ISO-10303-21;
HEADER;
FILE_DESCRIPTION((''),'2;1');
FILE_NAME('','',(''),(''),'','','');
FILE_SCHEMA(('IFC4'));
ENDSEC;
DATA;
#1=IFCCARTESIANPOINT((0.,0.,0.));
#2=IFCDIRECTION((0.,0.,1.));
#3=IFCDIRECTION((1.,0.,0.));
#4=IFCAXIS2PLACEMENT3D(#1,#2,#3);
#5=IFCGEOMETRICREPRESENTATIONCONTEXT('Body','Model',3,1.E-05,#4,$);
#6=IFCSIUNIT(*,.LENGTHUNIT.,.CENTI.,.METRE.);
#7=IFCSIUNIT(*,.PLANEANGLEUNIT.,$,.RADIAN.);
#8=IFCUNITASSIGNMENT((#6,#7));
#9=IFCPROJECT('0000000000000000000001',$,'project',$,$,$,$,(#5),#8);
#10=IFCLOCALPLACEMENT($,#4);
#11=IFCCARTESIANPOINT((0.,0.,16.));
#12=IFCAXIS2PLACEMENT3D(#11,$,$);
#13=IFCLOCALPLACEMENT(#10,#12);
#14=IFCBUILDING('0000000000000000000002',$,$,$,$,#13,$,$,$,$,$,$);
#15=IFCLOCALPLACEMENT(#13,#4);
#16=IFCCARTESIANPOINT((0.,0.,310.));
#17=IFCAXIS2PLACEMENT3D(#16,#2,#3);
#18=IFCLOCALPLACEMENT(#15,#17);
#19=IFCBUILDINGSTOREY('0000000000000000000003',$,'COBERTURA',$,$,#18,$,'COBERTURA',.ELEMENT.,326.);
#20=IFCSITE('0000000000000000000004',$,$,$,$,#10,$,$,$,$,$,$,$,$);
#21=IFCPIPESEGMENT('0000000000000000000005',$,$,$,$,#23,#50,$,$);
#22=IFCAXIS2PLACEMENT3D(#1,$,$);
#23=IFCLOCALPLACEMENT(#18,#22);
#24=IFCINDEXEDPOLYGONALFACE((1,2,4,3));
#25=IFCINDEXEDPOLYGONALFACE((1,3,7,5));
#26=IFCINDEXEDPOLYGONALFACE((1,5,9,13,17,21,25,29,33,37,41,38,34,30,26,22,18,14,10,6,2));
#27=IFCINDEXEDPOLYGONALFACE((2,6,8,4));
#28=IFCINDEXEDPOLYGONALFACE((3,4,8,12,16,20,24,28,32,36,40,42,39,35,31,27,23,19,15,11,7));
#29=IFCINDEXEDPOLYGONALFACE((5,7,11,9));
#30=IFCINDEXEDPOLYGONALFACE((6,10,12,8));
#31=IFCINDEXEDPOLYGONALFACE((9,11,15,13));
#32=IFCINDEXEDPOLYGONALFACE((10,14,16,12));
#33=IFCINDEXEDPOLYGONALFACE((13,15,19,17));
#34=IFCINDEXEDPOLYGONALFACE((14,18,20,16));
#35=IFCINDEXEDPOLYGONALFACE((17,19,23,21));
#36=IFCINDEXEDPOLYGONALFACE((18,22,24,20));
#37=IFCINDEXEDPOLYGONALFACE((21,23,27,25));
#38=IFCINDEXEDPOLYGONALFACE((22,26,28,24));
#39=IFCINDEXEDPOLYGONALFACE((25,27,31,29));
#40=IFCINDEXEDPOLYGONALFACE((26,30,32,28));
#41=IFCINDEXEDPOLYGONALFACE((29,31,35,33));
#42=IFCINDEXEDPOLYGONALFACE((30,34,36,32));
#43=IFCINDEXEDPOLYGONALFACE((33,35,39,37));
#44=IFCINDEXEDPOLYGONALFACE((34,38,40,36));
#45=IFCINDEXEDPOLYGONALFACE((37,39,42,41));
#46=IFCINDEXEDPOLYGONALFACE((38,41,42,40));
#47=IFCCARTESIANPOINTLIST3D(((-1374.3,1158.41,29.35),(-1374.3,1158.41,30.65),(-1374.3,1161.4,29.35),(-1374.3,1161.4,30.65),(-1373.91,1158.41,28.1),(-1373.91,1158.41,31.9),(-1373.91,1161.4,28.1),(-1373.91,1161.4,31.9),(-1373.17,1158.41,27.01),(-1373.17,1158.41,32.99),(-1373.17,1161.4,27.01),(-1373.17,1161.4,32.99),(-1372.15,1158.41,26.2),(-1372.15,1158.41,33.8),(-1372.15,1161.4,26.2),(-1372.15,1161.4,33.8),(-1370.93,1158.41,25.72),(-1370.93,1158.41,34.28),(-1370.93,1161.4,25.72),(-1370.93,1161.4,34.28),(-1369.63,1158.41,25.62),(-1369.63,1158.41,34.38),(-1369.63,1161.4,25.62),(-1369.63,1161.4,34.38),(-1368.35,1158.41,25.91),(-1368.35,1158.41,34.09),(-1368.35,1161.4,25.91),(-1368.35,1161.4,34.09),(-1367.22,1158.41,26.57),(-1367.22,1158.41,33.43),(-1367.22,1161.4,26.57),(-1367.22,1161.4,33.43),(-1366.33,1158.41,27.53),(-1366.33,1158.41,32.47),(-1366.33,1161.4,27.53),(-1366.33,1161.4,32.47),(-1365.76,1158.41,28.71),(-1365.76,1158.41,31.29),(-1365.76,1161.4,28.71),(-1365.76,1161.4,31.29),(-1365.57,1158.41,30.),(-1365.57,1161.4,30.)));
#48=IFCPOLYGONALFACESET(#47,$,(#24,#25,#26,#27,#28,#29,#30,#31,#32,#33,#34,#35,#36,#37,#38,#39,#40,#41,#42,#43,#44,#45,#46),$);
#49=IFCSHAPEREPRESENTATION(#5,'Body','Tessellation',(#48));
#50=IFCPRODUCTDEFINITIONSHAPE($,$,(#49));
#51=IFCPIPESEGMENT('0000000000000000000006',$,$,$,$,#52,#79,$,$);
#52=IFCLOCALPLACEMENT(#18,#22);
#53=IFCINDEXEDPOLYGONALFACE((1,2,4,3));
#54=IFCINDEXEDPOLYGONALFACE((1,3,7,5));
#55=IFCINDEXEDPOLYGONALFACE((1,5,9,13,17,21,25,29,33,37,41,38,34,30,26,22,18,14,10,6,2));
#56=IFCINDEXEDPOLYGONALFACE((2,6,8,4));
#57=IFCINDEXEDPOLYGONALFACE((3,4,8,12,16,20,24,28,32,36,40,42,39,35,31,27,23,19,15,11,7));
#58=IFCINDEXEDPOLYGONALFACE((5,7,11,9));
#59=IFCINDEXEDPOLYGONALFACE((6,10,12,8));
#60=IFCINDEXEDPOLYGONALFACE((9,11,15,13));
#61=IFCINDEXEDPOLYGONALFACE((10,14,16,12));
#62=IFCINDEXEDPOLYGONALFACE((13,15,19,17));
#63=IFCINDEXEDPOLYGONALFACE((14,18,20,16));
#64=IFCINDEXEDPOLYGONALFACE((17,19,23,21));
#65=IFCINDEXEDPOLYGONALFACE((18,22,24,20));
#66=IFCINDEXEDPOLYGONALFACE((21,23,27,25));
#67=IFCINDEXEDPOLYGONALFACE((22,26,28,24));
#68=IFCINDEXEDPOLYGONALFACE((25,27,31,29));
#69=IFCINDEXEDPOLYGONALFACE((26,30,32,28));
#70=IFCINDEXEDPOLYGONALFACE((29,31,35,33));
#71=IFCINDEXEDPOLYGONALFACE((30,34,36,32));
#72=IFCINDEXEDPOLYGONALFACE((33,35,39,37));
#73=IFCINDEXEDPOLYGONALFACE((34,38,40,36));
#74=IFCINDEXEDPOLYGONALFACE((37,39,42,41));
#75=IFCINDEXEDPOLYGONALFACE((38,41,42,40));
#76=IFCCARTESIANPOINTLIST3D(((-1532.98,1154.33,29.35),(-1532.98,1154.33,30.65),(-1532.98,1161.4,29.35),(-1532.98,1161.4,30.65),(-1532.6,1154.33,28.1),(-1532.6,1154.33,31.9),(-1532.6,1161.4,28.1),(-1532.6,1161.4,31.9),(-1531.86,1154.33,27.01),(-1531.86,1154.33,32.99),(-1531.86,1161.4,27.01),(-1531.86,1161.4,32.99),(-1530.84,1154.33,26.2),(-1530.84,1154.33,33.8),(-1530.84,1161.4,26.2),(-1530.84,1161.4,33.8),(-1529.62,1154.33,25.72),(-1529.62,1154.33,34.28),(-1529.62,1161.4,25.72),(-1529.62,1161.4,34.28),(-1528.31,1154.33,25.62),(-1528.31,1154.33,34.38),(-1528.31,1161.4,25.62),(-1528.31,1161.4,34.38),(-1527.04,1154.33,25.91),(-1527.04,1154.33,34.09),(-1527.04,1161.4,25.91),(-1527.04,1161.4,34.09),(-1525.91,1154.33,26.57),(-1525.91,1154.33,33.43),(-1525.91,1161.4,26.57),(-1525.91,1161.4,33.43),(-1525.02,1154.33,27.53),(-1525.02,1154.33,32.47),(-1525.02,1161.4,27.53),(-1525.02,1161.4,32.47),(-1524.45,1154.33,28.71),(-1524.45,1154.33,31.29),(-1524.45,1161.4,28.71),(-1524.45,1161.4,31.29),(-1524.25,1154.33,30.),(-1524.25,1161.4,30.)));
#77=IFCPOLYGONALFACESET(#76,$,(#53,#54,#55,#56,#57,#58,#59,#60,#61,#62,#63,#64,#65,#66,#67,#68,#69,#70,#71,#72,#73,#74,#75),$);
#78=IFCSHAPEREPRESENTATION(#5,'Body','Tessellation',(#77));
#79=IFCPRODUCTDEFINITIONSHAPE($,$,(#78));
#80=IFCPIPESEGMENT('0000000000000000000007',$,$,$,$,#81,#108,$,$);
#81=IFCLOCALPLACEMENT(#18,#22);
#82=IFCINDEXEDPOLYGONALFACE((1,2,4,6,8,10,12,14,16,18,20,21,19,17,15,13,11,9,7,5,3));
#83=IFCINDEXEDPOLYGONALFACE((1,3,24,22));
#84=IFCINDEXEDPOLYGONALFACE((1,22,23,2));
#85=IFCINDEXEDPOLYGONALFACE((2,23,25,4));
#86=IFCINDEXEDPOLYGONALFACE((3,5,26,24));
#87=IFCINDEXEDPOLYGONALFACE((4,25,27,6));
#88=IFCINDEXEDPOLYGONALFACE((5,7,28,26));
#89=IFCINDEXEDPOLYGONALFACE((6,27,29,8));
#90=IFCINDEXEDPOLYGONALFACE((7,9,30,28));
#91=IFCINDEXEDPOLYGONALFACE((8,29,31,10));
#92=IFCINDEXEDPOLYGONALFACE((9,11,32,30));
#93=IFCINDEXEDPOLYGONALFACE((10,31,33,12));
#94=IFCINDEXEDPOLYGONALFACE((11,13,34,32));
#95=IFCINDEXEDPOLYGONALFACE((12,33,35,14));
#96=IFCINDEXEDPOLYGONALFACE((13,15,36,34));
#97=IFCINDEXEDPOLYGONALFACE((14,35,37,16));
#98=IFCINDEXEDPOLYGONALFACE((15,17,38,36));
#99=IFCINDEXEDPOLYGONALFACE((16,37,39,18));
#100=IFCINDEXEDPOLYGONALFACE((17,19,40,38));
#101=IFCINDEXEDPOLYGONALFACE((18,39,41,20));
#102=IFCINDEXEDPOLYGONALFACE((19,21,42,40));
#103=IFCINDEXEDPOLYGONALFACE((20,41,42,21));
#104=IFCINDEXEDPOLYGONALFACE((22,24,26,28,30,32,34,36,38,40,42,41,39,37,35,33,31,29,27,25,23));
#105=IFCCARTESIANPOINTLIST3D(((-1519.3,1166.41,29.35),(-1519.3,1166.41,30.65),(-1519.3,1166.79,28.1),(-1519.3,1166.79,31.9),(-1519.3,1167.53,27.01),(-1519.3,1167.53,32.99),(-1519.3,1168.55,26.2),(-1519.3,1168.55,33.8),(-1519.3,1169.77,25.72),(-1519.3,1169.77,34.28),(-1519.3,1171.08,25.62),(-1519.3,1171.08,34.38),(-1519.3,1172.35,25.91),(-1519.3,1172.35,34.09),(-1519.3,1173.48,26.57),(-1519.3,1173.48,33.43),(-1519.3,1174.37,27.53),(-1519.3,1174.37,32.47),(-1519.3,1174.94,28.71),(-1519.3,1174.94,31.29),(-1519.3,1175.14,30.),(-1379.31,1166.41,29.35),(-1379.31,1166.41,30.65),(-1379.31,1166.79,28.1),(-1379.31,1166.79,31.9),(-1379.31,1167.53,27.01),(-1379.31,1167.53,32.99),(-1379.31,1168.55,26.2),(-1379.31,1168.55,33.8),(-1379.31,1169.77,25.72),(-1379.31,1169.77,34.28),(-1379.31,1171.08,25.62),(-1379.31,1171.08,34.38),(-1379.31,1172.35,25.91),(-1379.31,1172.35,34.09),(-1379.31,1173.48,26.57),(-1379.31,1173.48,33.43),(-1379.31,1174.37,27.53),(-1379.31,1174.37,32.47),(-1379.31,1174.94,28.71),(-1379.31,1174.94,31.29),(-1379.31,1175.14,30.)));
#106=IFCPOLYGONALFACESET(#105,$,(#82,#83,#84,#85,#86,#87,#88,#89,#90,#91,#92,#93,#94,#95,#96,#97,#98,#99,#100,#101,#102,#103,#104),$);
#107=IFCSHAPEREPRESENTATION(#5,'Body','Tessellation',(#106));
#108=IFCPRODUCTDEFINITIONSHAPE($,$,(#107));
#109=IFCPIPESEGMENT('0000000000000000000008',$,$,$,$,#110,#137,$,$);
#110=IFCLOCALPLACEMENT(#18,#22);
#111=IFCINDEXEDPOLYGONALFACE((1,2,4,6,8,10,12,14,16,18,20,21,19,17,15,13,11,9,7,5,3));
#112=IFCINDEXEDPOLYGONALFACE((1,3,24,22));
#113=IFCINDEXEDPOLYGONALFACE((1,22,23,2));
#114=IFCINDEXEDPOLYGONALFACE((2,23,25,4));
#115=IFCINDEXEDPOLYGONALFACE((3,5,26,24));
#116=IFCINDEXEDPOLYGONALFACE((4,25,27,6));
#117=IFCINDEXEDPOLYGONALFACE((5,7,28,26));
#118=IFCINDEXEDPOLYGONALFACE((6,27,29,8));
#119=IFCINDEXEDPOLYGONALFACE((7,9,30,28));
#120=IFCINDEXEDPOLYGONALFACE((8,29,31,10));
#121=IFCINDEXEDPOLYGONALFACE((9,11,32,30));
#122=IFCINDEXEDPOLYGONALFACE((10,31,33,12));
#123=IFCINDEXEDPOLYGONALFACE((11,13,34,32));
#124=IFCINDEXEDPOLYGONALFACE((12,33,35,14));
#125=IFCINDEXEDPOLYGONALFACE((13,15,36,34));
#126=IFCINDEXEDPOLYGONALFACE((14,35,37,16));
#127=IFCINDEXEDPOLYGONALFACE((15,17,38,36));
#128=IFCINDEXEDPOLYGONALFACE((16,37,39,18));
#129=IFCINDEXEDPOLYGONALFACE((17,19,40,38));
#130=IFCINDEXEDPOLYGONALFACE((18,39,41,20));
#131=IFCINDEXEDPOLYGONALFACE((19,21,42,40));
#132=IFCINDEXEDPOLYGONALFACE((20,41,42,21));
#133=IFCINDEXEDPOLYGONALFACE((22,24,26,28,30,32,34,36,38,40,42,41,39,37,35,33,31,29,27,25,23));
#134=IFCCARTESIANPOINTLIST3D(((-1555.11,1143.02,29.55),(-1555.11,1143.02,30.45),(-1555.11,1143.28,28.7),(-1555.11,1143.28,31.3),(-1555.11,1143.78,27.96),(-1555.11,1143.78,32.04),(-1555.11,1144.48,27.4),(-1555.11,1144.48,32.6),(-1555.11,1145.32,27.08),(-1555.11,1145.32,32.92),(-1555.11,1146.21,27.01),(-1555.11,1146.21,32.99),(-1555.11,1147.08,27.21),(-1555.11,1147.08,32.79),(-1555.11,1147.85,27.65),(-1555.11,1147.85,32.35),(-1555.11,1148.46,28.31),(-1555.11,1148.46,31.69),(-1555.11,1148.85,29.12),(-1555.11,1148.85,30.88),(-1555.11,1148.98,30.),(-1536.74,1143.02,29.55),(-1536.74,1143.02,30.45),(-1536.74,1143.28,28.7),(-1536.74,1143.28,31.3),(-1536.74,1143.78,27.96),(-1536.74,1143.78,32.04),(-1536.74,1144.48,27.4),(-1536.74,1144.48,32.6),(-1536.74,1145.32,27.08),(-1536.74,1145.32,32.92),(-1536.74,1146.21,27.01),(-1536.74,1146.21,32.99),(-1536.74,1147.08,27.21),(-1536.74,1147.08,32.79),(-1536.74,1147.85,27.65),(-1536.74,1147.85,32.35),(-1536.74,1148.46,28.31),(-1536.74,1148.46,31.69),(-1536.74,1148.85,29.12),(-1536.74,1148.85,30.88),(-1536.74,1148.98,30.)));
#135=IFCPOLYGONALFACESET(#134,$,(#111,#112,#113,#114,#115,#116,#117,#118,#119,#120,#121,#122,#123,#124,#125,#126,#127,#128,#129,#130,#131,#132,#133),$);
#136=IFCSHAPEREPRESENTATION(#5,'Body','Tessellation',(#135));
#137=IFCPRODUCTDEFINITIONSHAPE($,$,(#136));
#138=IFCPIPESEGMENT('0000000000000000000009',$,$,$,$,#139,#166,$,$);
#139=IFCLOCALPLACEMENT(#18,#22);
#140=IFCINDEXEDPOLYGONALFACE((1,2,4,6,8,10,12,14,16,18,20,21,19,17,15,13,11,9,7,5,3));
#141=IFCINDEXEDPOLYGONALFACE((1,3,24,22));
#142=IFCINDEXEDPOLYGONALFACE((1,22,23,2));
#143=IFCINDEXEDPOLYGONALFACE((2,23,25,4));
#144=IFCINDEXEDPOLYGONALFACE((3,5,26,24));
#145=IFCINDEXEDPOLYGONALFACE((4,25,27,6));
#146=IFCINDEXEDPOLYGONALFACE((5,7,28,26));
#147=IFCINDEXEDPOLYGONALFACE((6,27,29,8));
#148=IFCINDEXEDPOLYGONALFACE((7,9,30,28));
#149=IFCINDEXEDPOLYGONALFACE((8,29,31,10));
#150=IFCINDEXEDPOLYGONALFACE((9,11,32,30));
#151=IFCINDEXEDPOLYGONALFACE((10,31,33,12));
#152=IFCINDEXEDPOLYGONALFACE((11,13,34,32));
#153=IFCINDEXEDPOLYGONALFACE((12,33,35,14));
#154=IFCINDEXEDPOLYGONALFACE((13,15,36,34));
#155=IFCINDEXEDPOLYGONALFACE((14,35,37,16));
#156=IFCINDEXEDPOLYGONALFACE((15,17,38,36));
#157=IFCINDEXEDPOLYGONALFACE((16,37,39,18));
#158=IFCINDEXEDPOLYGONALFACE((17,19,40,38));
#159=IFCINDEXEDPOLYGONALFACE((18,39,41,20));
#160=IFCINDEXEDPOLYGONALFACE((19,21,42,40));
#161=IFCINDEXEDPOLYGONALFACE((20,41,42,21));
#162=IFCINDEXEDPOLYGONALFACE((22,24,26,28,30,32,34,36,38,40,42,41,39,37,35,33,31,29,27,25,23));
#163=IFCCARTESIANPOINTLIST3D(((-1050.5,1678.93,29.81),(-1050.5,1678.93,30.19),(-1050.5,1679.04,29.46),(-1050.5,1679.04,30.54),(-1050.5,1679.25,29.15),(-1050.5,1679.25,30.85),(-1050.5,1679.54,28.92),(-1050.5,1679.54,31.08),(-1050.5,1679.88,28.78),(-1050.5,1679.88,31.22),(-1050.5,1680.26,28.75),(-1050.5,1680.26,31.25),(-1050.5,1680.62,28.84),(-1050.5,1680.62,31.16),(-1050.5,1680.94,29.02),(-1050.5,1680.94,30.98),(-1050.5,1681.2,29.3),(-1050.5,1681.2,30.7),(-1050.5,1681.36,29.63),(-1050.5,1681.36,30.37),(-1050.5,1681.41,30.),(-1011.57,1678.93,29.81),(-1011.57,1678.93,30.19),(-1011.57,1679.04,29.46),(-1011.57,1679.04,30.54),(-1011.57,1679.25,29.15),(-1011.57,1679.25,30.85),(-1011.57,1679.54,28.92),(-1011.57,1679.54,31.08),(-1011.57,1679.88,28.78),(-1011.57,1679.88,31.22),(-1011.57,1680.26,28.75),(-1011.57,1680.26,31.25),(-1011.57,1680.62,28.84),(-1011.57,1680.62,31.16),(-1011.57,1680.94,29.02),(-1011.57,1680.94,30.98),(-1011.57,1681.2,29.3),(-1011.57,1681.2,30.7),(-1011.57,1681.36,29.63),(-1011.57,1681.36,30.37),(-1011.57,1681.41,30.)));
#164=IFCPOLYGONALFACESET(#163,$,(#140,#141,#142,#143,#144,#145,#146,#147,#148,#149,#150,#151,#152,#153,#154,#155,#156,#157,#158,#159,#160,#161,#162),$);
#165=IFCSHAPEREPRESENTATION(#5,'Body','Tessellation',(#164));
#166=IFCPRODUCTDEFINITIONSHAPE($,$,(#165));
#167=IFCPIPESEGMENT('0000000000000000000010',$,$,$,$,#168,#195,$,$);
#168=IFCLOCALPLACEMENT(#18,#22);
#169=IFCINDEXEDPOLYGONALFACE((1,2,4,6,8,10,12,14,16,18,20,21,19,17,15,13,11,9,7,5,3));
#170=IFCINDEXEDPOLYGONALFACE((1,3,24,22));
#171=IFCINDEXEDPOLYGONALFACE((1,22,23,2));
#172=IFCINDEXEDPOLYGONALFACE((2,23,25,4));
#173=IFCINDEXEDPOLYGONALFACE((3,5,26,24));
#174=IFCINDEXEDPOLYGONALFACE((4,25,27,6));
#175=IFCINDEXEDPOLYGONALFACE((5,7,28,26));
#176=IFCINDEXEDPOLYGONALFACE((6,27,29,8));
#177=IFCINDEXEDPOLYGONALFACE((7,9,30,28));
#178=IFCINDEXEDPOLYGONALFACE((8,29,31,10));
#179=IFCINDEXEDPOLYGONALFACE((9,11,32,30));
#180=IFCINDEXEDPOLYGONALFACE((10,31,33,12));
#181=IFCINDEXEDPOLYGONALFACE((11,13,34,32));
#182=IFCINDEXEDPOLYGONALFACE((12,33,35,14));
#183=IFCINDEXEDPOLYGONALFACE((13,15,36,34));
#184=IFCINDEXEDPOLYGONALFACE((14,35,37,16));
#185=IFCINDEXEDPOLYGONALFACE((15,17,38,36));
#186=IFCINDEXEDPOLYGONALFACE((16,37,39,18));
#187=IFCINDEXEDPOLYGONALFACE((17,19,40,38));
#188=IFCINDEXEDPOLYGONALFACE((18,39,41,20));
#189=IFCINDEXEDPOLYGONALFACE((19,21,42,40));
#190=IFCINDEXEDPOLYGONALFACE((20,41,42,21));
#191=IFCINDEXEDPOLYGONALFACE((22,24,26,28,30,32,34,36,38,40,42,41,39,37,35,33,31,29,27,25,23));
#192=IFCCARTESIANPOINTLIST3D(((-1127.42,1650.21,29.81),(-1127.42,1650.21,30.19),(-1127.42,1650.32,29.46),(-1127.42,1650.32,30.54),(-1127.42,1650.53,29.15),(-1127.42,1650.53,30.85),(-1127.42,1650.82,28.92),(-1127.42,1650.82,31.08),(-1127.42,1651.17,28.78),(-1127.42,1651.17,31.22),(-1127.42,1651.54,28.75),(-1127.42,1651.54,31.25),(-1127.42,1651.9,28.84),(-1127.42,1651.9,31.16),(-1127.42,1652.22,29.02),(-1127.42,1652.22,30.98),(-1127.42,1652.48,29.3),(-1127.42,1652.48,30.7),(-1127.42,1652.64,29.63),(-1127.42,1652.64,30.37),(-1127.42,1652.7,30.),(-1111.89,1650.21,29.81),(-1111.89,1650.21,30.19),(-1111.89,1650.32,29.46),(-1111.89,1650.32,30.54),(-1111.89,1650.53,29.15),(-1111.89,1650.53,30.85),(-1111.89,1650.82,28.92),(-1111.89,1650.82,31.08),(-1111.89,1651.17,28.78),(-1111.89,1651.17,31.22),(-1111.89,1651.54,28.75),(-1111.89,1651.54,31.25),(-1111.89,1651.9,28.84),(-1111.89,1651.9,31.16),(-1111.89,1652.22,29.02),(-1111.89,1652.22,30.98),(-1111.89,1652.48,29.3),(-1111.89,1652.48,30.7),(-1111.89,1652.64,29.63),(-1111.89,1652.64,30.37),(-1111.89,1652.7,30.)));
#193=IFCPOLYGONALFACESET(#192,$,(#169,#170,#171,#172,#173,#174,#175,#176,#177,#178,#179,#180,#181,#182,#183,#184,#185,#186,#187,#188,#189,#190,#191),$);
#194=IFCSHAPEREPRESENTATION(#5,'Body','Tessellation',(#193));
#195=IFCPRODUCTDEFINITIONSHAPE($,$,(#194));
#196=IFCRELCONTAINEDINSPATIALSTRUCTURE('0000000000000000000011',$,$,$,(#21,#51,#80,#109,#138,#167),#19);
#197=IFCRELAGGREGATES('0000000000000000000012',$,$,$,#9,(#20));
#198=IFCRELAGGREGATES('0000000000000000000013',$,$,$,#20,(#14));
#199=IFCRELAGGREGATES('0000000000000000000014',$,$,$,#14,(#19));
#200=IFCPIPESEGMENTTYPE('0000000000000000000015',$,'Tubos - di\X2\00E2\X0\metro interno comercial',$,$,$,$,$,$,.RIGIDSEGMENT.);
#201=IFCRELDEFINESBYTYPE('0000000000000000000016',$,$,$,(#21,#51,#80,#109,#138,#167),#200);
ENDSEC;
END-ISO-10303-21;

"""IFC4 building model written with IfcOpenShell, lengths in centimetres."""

from ifc_helpers import new_model, si_unit, frame, origin_with_axes, origin_2d_with_axis, place, context, project, spatial, circle, extrude, type_object, element, save


model = new_model("IFC4")

# Units and contexts
model_context = context("Model", 3, precision=1e-05, world=origin_with_axes(), identifier="Body")
ifc_project = project(units=[si_unit("LENGTHUNIT", "METRE", prefix="CENTI"), si_unit("PLANEANGLEUNIT", "RADIAN")], contexts=[model_context])

# Site, building, storey
site_placement = place(None, origin_with_axes())
site = spatial("IfcSite", under=ifc_project, at=site_placement)
building_placement = place(site_placement, frame((0.0, 0.0, 16.0)))
building = spatial("IfcBuilding", under=site, at=building_placement)
placement = place(building_placement, origin_with_axes())
storey_placement = place(placement, frame((0.0, 0.0, 310.0), z_axis=(0.0, 0.0, 1.0), x_axis=(1.0, 0.0, 0.0)))
storey = spatial("IfcBuildingStorey", under=building, at=storey_placement, Name="COBERTURA", LongName="COBERTURA", CompositionType="ELEMENT", Elevation=326.0)

# Pipe segments
pipe_segment_type = type_object("IfcPipeSegmentType", Name="Tubos - diâmetro interno comercial", PredefinedType="RIGIDSEGMENT")
pipe_segment_1_placement = place(storey_placement, frame((-1369.96, 1159.9, 34.39), z_axis=(0.0, 0.0, 1.0), x_axis=(1.0, 0.0, 0.0)))
element("IfcPipeSegment", 1, at=pipe_segment_1_placement, inside=storey, type_object=pipe_segment_type, context=model_context, shape_type="SolidModel", body=[
    extrude(circle(Radius=4.39, at=origin_2d_with_axis()), frame((0.0, 1.49, -4.39), z_axis=(0.0, -1.0, 0.0), x_axis=(1.0, 0.0, 0.0)), (0.0, 0.0, 1.0), 2.99),
])
pipe_segment_2_placement = place(storey_placement, frame((-1528.64, 1157.87, 34.39), z_axis=(0.0, 0.0, 1.0), x_axis=(1.0, 0.0, 0.0)))
element("IfcPipeSegment", 2, at=pipe_segment_2_placement, inside=storey, type_object=pipe_segment_type, context=model_context, shape_type="SolidModel", body=[
    extrude(circle(Radius=4.39, at=origin_2d_with_axis()), frame((0.0, 3.53, -4.39), z_axis=(0.0, -1.0, 0.0), x_axis=(1.0, 0.0, 0.0)), (0.0, 0.0, 1.0), 7.07),
])
pipe_segment_3_placement = place(storey_placement, frame((-1449.3, 1170.75, 34.39), z_axis=(0.0, 0.0, 1.0), x_axis=(1.0, 0.0, 0.0)))
element("IfcPipeSegment", 3, at=pipe_segment_3_placement, inside=storey, type_object=pipe_segment_type, context=model_context, shape_type="SolidModel", body=[
    extrude(circle(Radius=4.39, at=origin_2d_with_axis()), frame((-70.0, 0.0, -4.39), z_axis=(1.0, 0.0, 0.0), x_axis=(0.0, 1.0, 0.0)), (0.0, 0.0, 1.0), 139.99),
])
pipe_segment_4_placement = place(storey_placement, frame((-1545.93, 1145.98, 33.0), z_axis=(0.0, 0.0, 1.0), x_axis=(1.0, 0.0, 0.0)))
element("IfcPipeSegment", 4, at=pipe_segment_4_placement, inside=storey, type_object=pipe_segment_type, context=model_context, shape_type="SolidModel", body=[
    extrude(circle(Radius=3.0, at=origin_2d_with_axis()), frame((9.19, 0.0, -3.0), z_axis=(-1.0, 0.0, 0.0), x_axis=(0.0, 1.0, 0.0)), (0.0, 0.0, 1.0), 18.37),
])
pipe_segment_5_placement = place(storey_placement, frame((-1031.03, 1680.16, 31.25), z_axis=(0.0, 0.0, 1.0), x_axis=(1.0, 0.0, 0.0)))
element("IfcPipeSegment", 5, at=pipe_segment_5_placement, inside=storey, type_object=pipe_segment_type, context=model_context, shape_type="SolidModel", body=[
    extrude(circle(Radius=1.25, at=origin_2d_with_axis()), frame((-19.46, 0.0, -1.25), z_axis=(1.0, 0.0, 0.0), x_axis=(0.0, 1.0, 0.0)), (0.0, 0.0, 1.0), 38.93),
])
pipe_segment_6_placement = place(storey_placement, frame((-1119.66, 1651.45, 31.25), z_axis=(0.0, 0.0, 1.0), x_axis=(1.0, 0.0, 0.0)))
element("IfcPipeSegment", 6, at=pipe_segment_6_placement, inside=storey, type_object=pipe_segment_type, context=model_context, shape_type="SolidModel", body=[
    extrude(circle(Radius=1.25, at=origin_2d_with_axis()), frame((7.76, 0.0, -1.25), z_axis=(-1.0, 0.0, 0.0), x_axis=(0.0, 1.0, 0.0)), (0.0, 0.0, 1.0), 15.53),
])

save(model, "model.ifc")
